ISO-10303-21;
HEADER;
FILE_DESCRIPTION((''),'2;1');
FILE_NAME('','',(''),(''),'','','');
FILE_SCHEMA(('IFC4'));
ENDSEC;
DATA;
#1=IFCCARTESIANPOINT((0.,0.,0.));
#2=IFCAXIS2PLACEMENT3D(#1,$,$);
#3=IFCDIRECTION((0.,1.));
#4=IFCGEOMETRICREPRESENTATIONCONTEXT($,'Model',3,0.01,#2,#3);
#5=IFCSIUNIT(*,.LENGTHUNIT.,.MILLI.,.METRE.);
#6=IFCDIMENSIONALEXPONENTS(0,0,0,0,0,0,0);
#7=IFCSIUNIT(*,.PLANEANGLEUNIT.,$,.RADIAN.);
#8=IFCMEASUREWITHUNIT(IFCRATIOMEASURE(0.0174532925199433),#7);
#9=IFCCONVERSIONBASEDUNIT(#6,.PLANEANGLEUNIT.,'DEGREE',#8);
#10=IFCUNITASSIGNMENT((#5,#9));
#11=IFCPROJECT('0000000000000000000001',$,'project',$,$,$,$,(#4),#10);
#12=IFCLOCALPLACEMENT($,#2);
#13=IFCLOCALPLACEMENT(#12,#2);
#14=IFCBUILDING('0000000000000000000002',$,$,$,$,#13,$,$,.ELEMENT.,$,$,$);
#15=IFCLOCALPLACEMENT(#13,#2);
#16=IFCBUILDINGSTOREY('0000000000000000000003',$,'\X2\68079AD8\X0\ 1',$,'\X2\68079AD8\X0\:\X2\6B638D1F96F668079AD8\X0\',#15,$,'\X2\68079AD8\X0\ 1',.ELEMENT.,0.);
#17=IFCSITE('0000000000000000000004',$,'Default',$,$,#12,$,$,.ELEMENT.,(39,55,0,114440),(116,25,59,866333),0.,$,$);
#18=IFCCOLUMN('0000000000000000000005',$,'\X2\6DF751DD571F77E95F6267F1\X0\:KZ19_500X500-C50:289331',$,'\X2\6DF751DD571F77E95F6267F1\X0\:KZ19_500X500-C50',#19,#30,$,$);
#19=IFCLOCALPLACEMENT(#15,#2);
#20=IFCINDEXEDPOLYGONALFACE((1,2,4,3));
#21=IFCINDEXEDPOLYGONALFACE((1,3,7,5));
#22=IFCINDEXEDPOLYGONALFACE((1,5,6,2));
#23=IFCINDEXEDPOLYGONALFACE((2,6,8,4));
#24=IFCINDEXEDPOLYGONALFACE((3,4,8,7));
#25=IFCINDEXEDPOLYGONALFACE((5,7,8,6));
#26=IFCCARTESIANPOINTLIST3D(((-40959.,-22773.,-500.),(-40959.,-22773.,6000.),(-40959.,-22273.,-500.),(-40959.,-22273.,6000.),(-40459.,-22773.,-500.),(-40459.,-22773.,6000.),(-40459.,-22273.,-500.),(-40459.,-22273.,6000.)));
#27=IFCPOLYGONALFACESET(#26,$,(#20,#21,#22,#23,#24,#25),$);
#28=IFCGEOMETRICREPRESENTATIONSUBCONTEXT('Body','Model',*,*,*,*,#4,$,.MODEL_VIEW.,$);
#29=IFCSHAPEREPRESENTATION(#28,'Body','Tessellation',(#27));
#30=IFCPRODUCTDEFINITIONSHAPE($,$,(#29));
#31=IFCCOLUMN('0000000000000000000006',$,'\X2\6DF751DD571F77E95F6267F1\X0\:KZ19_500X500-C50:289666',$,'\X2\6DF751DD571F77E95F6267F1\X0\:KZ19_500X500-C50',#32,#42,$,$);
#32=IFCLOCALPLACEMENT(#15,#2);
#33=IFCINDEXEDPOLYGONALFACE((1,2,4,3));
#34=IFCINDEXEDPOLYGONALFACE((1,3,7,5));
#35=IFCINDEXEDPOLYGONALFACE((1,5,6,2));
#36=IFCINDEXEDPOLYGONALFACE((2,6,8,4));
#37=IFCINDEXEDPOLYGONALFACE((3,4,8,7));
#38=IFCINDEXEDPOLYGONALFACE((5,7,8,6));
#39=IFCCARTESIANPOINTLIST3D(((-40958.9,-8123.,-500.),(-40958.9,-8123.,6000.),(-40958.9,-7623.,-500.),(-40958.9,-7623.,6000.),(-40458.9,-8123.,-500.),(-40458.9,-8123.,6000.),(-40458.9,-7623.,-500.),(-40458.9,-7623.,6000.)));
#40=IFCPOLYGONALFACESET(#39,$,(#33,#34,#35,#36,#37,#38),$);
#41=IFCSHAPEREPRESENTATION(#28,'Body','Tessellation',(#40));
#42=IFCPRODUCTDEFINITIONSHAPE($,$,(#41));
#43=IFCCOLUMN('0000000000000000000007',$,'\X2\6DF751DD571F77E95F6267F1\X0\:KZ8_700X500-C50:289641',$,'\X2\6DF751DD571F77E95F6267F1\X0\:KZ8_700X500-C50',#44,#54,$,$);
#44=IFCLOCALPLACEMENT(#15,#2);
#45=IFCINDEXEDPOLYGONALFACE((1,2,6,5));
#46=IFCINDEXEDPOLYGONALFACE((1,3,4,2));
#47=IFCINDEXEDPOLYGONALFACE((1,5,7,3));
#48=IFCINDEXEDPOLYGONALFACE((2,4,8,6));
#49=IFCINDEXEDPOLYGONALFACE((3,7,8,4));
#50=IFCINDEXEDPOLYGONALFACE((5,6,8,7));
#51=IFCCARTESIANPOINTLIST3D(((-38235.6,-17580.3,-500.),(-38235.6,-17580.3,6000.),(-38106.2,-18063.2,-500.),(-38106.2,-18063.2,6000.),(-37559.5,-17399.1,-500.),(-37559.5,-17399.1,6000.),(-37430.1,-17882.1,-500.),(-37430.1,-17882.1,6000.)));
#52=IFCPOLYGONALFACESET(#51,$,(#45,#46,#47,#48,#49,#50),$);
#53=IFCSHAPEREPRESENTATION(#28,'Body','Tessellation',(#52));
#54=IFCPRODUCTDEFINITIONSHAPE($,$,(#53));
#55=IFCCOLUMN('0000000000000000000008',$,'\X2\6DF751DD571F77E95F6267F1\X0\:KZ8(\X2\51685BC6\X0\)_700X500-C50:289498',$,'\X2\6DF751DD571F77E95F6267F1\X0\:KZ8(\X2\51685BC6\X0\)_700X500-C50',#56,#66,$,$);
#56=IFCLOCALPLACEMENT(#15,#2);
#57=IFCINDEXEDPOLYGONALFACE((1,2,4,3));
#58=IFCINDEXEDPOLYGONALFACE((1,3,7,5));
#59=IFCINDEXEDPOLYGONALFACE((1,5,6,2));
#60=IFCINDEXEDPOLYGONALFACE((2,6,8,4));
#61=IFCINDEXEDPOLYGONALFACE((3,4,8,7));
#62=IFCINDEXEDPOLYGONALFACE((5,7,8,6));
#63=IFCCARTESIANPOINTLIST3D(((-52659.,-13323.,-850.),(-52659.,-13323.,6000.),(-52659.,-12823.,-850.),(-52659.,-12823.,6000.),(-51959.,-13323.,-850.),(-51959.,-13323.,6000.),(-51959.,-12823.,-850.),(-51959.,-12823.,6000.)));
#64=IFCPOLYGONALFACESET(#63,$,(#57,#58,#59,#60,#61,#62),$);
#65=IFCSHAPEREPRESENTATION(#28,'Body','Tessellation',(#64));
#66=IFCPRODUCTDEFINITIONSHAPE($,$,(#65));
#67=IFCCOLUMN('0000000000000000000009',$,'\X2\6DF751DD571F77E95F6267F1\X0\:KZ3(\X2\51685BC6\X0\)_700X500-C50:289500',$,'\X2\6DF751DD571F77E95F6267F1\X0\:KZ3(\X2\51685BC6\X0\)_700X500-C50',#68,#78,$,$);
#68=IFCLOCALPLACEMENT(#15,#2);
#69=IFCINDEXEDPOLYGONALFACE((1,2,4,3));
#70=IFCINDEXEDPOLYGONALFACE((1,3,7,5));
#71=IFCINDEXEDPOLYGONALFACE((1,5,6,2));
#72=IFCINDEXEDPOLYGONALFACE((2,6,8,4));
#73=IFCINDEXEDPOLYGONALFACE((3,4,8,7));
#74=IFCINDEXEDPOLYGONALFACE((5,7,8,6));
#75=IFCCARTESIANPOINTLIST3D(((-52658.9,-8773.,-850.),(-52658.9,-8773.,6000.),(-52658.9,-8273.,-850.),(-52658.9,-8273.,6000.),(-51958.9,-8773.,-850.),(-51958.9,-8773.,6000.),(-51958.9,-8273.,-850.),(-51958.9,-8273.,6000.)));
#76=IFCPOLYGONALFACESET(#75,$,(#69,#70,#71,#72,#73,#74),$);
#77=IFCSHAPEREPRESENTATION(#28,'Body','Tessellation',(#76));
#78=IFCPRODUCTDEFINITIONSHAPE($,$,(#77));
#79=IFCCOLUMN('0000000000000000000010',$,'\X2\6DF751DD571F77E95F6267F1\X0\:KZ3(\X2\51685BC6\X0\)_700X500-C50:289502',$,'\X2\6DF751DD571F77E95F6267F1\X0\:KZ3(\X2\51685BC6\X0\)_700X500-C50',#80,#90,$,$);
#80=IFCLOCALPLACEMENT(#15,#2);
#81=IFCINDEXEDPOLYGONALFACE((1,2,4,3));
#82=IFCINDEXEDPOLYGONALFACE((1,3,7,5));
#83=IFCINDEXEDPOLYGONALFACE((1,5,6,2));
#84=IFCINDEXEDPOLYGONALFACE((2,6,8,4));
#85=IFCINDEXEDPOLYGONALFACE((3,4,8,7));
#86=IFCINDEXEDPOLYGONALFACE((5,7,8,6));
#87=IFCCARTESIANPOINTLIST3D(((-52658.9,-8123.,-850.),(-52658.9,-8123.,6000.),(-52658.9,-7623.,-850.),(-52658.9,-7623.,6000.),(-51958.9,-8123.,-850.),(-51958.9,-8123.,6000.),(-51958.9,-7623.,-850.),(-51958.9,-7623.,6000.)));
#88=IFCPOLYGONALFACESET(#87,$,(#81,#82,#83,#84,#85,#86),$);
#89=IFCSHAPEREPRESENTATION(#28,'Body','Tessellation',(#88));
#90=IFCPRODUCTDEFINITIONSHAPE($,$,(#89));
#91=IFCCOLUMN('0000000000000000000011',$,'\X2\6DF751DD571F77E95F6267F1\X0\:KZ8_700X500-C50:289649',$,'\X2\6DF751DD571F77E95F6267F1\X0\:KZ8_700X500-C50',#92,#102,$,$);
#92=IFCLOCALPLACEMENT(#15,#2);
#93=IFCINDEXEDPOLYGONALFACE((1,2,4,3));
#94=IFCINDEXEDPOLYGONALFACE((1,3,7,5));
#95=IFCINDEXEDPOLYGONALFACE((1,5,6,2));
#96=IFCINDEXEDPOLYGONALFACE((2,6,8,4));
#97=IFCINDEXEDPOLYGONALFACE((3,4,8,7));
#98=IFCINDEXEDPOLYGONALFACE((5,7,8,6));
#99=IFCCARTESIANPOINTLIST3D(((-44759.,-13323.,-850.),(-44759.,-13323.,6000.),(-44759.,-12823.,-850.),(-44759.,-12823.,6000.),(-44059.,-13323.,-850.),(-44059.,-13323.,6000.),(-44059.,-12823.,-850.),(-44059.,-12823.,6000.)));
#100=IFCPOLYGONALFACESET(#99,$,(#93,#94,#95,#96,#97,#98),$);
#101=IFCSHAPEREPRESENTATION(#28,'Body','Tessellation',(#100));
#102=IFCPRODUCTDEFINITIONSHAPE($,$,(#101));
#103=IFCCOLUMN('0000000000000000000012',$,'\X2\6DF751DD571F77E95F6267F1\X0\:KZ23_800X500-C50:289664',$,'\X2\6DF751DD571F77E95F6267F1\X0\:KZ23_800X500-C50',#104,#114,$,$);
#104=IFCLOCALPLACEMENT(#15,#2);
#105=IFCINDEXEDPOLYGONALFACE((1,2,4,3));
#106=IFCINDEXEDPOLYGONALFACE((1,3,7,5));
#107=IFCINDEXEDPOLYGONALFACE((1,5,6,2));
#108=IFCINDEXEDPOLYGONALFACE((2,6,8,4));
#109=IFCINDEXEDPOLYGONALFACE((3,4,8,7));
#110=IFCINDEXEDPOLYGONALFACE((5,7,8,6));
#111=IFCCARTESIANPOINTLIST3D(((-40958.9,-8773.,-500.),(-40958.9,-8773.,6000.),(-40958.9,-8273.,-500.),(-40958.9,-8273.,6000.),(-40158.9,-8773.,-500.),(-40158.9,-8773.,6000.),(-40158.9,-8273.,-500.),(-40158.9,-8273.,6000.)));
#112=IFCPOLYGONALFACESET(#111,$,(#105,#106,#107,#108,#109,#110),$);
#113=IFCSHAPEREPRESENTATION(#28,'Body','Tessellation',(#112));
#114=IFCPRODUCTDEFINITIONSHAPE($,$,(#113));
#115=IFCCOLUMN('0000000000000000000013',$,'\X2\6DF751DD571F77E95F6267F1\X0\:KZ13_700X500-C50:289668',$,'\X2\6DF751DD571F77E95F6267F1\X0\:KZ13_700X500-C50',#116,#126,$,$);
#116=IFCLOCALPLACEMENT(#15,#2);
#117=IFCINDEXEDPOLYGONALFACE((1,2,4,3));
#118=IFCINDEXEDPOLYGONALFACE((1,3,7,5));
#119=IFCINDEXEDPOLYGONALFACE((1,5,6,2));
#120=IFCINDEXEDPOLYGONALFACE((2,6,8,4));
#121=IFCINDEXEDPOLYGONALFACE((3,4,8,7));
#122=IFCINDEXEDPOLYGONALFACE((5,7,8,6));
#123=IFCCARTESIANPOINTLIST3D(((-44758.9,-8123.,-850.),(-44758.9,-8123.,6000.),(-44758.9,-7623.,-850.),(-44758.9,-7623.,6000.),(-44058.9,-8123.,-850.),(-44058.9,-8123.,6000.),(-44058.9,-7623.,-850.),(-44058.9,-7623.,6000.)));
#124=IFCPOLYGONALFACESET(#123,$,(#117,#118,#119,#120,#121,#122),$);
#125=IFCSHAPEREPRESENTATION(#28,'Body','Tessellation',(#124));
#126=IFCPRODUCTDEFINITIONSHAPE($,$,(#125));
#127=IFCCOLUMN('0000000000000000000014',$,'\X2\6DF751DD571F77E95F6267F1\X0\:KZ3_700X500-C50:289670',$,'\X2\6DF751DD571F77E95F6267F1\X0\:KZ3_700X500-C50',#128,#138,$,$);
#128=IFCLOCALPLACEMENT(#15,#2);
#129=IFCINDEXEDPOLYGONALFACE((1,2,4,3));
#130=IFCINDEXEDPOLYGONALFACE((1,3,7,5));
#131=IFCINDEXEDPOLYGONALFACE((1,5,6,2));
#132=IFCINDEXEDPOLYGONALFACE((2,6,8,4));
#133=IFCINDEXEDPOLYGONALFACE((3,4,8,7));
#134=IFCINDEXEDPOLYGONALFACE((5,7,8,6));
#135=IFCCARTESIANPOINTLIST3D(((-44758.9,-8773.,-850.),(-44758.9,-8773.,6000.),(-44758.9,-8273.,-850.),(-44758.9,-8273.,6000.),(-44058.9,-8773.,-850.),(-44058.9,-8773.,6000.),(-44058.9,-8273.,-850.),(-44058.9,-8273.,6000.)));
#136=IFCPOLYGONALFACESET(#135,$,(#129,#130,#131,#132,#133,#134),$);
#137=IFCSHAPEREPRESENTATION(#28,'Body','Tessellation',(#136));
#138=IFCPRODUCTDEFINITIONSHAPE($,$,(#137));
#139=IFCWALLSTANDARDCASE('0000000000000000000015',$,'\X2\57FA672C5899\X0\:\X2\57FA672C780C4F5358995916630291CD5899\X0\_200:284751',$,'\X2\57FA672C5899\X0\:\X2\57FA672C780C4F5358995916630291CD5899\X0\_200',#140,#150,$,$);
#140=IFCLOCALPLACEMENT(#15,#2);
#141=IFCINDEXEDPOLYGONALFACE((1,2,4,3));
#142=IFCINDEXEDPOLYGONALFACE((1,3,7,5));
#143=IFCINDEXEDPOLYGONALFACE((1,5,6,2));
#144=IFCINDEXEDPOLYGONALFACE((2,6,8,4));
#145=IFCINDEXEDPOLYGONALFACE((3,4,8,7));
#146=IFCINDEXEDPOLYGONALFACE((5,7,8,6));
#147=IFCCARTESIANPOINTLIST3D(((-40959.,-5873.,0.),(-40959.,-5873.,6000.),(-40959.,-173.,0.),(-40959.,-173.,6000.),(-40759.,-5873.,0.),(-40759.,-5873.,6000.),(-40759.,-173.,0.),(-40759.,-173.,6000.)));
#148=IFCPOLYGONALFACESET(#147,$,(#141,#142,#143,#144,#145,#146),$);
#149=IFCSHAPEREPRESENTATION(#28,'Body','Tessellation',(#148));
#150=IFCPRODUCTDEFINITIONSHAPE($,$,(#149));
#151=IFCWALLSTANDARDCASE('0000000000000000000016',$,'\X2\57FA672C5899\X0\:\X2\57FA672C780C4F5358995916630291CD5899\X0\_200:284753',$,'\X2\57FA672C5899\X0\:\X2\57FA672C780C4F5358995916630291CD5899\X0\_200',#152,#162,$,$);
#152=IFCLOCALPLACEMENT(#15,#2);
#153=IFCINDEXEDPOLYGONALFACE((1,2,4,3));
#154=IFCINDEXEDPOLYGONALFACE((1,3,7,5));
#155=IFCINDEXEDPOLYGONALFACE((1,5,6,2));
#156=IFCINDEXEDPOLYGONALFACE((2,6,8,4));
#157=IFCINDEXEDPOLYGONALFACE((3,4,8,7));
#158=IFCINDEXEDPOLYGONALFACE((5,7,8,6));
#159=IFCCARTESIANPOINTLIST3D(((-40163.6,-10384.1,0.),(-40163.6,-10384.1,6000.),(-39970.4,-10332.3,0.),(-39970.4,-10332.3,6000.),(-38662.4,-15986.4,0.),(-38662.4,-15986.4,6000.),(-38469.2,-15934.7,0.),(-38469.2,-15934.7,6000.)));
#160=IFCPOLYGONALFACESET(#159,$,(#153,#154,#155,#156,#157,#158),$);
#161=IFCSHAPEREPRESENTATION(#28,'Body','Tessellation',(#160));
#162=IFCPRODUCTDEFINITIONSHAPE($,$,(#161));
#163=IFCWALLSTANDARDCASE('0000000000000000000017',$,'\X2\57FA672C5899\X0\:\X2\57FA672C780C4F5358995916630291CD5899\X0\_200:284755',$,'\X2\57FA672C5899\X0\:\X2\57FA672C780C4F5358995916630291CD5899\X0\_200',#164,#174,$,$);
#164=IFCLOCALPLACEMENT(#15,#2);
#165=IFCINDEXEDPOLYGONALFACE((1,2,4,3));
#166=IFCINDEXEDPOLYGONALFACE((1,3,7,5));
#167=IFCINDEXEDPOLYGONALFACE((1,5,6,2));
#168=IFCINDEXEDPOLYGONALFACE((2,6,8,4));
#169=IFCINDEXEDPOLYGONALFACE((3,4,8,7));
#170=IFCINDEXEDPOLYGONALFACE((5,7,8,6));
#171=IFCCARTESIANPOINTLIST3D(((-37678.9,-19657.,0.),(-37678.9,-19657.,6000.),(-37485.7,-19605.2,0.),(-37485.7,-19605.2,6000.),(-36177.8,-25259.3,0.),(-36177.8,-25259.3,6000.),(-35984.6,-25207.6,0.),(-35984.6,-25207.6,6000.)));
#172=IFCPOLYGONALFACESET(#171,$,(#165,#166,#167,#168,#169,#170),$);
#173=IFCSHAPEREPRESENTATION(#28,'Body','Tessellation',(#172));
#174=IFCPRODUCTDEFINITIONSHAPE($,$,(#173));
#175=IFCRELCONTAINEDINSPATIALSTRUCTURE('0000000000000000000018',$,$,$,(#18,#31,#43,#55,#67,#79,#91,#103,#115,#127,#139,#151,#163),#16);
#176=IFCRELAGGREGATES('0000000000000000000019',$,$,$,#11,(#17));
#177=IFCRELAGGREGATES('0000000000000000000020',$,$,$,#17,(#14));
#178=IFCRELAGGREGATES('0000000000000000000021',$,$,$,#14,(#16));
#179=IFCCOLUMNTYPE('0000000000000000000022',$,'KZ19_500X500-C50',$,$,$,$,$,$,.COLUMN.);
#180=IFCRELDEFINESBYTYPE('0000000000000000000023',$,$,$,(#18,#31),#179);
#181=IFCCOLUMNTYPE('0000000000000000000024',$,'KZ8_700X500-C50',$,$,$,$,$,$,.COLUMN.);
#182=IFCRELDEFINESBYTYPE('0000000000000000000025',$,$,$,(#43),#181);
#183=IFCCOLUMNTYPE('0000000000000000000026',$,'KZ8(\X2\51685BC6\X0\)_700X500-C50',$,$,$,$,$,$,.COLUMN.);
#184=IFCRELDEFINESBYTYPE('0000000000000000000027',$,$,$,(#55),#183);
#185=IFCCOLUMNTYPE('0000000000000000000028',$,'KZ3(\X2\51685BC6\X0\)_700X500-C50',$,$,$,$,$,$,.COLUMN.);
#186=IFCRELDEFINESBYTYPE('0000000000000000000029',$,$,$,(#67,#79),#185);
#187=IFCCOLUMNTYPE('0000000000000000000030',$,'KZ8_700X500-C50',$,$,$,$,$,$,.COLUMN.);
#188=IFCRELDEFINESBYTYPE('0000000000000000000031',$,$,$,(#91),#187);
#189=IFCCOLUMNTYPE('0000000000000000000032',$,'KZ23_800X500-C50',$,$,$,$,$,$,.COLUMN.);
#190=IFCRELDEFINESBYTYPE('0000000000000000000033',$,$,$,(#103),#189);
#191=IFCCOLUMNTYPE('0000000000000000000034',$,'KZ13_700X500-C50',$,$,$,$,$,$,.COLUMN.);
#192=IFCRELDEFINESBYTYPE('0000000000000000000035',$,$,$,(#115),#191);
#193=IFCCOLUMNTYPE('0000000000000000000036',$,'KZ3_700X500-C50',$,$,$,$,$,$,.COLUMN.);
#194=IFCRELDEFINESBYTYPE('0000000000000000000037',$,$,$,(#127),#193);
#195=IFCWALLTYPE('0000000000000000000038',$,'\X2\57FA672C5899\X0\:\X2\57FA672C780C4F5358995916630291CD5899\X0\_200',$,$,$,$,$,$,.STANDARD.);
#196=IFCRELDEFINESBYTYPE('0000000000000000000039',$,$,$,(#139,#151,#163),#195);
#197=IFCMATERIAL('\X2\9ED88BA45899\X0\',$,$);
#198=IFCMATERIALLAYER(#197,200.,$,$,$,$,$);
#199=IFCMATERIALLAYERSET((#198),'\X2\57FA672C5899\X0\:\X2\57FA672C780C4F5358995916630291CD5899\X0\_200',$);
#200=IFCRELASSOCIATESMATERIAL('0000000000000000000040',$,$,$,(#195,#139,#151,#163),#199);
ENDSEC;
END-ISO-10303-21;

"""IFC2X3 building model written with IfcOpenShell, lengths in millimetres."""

from ifc_helpers import new_model, entity, si_unit, converted_unit, direction, frame, frame_2d, origin, origin_2d_with_axis, place, context, subcontext, project, spatial, rectangle, extrude, source, transform, mapped, material, layer, layer_set, layer_usage, type_object, type_shapes, element, save


model = new_model("IFC2X3")

# Units and contexts
model_context = context("Model", 3, precision=0.01, world=origin(), true_north=direction((0.0, 1.0)))
body_context = subcontext(model_context, "Body", "Model", "MODEL_VIEW")
ifc_project = project(units=[si_unit("LENGTHUNIT", "METRE", prefix="MILLI"), converted_unit("PLANEANGLEUNIT", "DEGREE", entity("IfcRatioMeasure", 0.0174532925199433), si_unit("PLANEANGLEUNIT", "RADIAN"), dimensions=[0, 0, 0, 0, 0, 0, 0])], contexts=[model_context])

# Site, building, storey
site_placement = place(None, origin())
site = spatial("IfcSite", under=ifc_project, at=site_placement, Name="Default", CompositionType="ELEMENT", RefLatitude=(39, 55, 0, 114440), RefLongitude=(116, 25, 59, 866333), RefElevation=0.0)
building_placement = place(site_placement, origin())
building = spatial("IfcBuilding", under=site, at=building_placement, CompositionType="ELEMENT")
storey_placement = place(building_placement, origin())
storey = spatial("IfcBuildingStorey", under=building, at=storey_placement, Name="标高 1", ObjectType="标高:正负零标高", LongName="标高 1", CompositionType="ELEMENT", Elevation=0.0)

# Columns
column_type_1 = type_object("IfcColumnType", Name="KZ19_500X500-C50", PredefinedType="COLUMN")
shared_shape_1 = source(origin(), body_context, "Body", "SweptSolid", [
    extrude(rectangle(XDim=500.0, YDim=500.0, at=origin_2d_with_axis()), frame((0.0, 0.0, -500.0), z_axis=(0.0, 0.0, 1.0), x_axis=(0.0, -1.0, 0.0)), (0.0, 0.0, 1.0), 6500.0),
])
type_shapes(column_type_1, [shared_shape_1])
for number, where, name in (
    (1, (-40709.0, -22523.0, 0.0), "混凝土矩形柱:KZ19_500X500-C50:289331"),
    (2, (-40708.9, -7873.0, 0.0), "混凝土矩形柱:KZ19_500X500-C50:289666"),
):
    element("IfcColumn", number, at=place(building_placement, frame(where)), inside=storey, type_object=column_type_1, Name=name, ObjectType="混凝土矩形柱:KZ19_500X500-C50", context=body_context, shape_type="MappedRepresentation", body=[
        mapped(shared_shape_1, transform((0.0, 0.0, 0.0), scale=1.0)),
    ])
column_type_2 = type_object("IfcColumnType", Name="KZ8_700X500-C50", PredefinedType="COLUMN")
shared_shape_2 = source(origin(), body_context, "Body", "SweptSolid", [
    extrude(rectangle(XDim=500.0, YDim=700.0, at=origin_2d_with_axis()), frame((0.0, 0.0, -500.0), z_axis=(0.0, 0.0, 1.0), x_axis=(0.0, -1.0, 0.0)), (0.0, 0.0, 1.0), 6500.0),
])
type_shapes(column_type_2, [shared_shape_2])
column_1_placement = place(building_placement, frame((-37832.9, -17731.2, 0.0), z_axis=(0.0, 0.0, 1.0), x_axis=(0.965926, 0.258819, 0.0)))
element("IfcColumn", 3, at=column_1_placement, inside=storey, type_object=column_type_2, Name="混凝土矩形柱:KZ8_700X500-C50:289641", ObjectType="混凝土矩形柱:KZ8_700X500-C50", context=body_context, shape_type="MappedRepresentation", body=[
    mapped(shared_shape_2, transform((0.0, 0.0, 0.0), scale=1.0)),
])
column_type_3 = type_object("IfcColumnType", Name="KZ8(全密)_700X500-C50", PredefinedType="COLUMN")
shared_shape_3 = source(origin(), body_context, "Body", "SweptSolid", [
    extrude(rectangle(XDim=500.0, YDim=700.0, at=origin_2d_with_axis()), frame((0.0, 0.0, -850.0), z_axis=(0.0, 0.0, 1.0), x_axis=(0.0, -1.0, 0.0)), (0.0, 0.0, 1.0), 6850.0),
])
type_shapes(column_type_3, [shared_shape_3])
column_2_placement = place(building_placement, frame((-52309.0, -13073.0, 0.0)))
element("IfcColumn", 4, at=column_2_placement, inside=storey, type_object=column_type_3, Name="混凝土矩形柱:KZ8(全密)_700X500-C50:289498", ObjectType="混凝土矩形柱:KZ8(全密)_700X500-C50", context=body_context, shape_type="MappedRepresentation", body=[
    mapped(shared_shape_3, transform((0.0, 0.0, 0.0), scale=1.0)),
])
column_type_4 = type_object("IfcColumnType", Name="KZ3(全密)_700X500-C50", PredefinedType="COLUMN")
shared_shape_4 = source(origin(), body_context, "Body", "SweptSolid", [
    extrude(rectangle(XDim=500.0, YDim=700.0, at=origin_2d_with_axis()), frame((0.0, 0.0, -850.0), z_axis=(0.0, 0.0, 1.0), x_axis=(0.0, -1.0, 0.0)), (0.0, 0.0, 1.0), 6850.0),
])
type_shapes(column_type_4, [shared_shape_4])
for number, where, name in (
    (5, (-52308.9, -8523.0, 0.0), "混凝土矩形柱:KZ3(全密)_700X500-C50:289500"),
    (6, (-52308.9, -7873.0, 0.0), "混凝土矩形柱:KZ3(全密)_700X500-C50:289502"),
):
    element("IfcColumn", number, at=place(building_placement, frame(where)), inside=storey, type_object=column_type_4, Name=name, ObjectType="混凝土矩形柱:KZ3(全密)_700X500-C50", context=body_context, shape_type="MappedRepresentation", body=[
        mapped(shared_shape_4, transform((0.0, 0.0, 0.0), scale=1.0)),
    ])
column_type_5 = type_object("IfcColumnType", Name="KZ8_700X500-C50", PredefinedType="COLUMN")
shared_shape_5 = source(origin(), body_context, "Body", "SweptSolid", [
    extrude(rectangle(XDim=500.0, YDim=700.0, at=origin_2d_with_axis()), frame((0.0, 0.0, -850.0), z_axis=(0.0, 0.0, 1.0), x_axis=(0.0, -1.0, 0.0)), (0.0, 0.0, 1.0), 6850.0),
])
type_shapes(column_type_5, [shared_shape_5])
column_3_placement = place(building_placement, frame((-44409.0, -13073.0, 0.0)))
element("IfcColumn", 7, at=column_3_placement, inside=storey, type_object=column_type_5, Name="混凝土矩形柱:KZ8_700X500-C50:289649", ObjectType="混凝土矩形柱:KZ8_700X500-C50", context=body_context, shape_type="MappedRepresentation", body=[
    mapped(shared_shape_5, transform((0.0, 0.0, 0.0), scale=1.0)),
])
column_type_6 = type_object("IfcColumnType", Name="KZ23_800X500-C50", PredefinedType="COLUMN")
shared_shape_6 = source(origin(), body_context, "Body", "SweptSolid", [
    extrude(rectangle(XDim=500.0, YDim=800.0, at=origin_2d_with_axis()), frame((0.0, 0.0, -500.0), z_axis=(0.0, 0.0, 1.0), x_axis=(0.0, -1.0, 0.0)), (0.0, 0.0, 1.0), 6500.0),
])
type_shapes(column_type_6, [shared_shape_6])
column_4_placement = place(building_placement, frame((-40558.9, -8523.0, 0.0)))
element("IfcColumn", 8, at=column_4_placement, inside=storey, type_object=column_type_6, Name="混凝土矩形柱:KZ23_800X500-C50:289664", ObjectType="混凝土矩形柱:KZ23_800X500-C50", context=body_context, shape_type="MappedRepresentation", body=[
    mapped(shared_shape_6, transform((0.0, 0.0, 0.0), scale=1.0)),
])
column_type_7 = type_object("IfcColumnType", Name="KZ13_700X500-C50", PredefinedType="COLUMN")
shared_shape_7 = source(origin(), body_context, "Body", "SweptSolid", [
    extrude(rectangle(XDim=500.0, YDim=700.0, at=origin_2d_with_axis()), frame((0.0, 0.0, -850.0), z_axis=(0.0, 0.0, 1.0), x_axis=(0.0, -1.0, 0.0)), (0.0, 0.0, 1.0), 6850.0),
])
type_shapes(column_type_7, [shared_shape_7])
column_5_placement = place(building_placement, frame((-44408.9, -7873.0, 0.0)))
element("IfcColumn", 9, at=column_5_placement, inside=storey, type_object=column_type_7, Name="混凝土矩形柱:KZ13_700X500-C50:289668", ObjectType="混凝土矩形柱:KZ13_700X500-C50", context=body_context, shape_type="MappedRepresentation", body=[
    mapped(shared_shape_7, transform((0.0, 0.0, 0.0), scale=1.0)),
])
column_type_8 = type_object("IfcColumnType", Name="KZ3_700X500-C50", PredefinedType="COLUMN")
shared_shape_8 = source(origin(), body_context, "Body", "SweptSolid", [
    extrude(rectangle(XDim=500.0, YDim=700.0, at=origin_2d_with_axis()), frame((0.0, 0.0, -850.0), z_axis=(0.0, 0.0, 1.0), x_axis=(0.0, -1.0, 0.0)), (0.0, 0.0, 1.0), 6850.0),
])
type_shapes(column_type_8, [shared_shape_8])
column_6_placement = place(building_placement, frame((-44408.9, -8523.0, 0.0)))
element("IfcColumn", 10, at=column_6_placement, inside=storey, type_object=column_type_8, Name="混凝土矩形柱:KZ3_700X500-C50:289670", ObjectType="混凝土矩形柱:KZ3_700X500-C50", context=body_context, shape_type="MappedRepresentation", body=[
    mapped(shared_shape_8, transform((0.0, 0.0, 0.0), scale=1.0)),
])

# Walls
ifc_material = material(Name="默认墙")
ifc_layer_1 = layer(ifc_material, 200.0)
ifc_layer_set_1 = layer_set([ifc_layer_1], Name="基本墙:基本砌体墙外挂重墙_200")
ifc_layer_usage_1 = layer_usage(ifc_layer_set_1, "AXIS2", "NEGATIVE", 100.0)
wall_type_1 = type_object("IfcWallType", Name="基本墙:基本砌体墙外挂重墙_200", PredefinedType="STANDARD", material=ifc_layer_set_1)
wall_1_placement = place(building_placement, frame((-40859.0, -5873.0, 0.0), z_axis=(0.0, 0.0, 1.0), x_axis=(0.0, 1.0, 0.0)))
element("IfcWallStandardCase", 11, at=wall_1_placement, inside=storey, type_object=wall_type_1, material=ifc_layer_usage_1, Name="基本墙:基本砌体墙外挂重墙_200:284751", ObjectType="基本墙:基本砌体墙外挂重墙_200", context=body_context, shape_type="SweptSolid", body=[
    extrude(rectangle(XDim=5700.0, YDim=200.0, at=frame_2d((2850.0, 0.0), x_axis=(-1.0, 0.0))), origin(), (0.0, 0.0, 1.0), 6000.0),
])
ifc_layer_usage_2 = layer_usage(ifc_layer_set_1, "AXIS2", "NEGATIVE", 100.0)
wall_2_placement = place(building_placement, frame((-38565.8, -15960.6, 0.0), z_axis=(0.0, 0.0, 1.0), x_axis=(-0.258819, 0.965926, 0.0)))
element("IfcWallStandardCase", 12, at=wall_2_placement, inside=storey, type_object=wall_type_1, material=ifc_layer_usage_2, Name="基本墙:基本砌体墙外挂重墙_200:284753", ObjectType="基本墙:基本砌体墙外挂重墙_200", context=body_context, shape_type="SweptSolid", body=[
    extrude(rectangle(XDim=5800.0, YDim=200.0, at=frame_2d((2900.0, 0.0), x_axis=(-1.0, 0.0))), origin(), (0.0, 0.0, 1.0), 6000.0),
])
ifc_layer_usage_3 = layer_usage(ifc_layer_set_1, "AXIS2", "NEGATIVE", 100.0)
wall_3_placement = place(building_placement, frame((-36081.2, -25233.4, 0.0), z_axis=(0.0, 0.0, 1.0), x_axis=(-0.258819, 0.965926, 0.0)))
element("IfcWallStandardCase", 13, at=wall_3_placement, inside=storey, type_object=wall_type_1, material=ifc_layer_usage_3, Name="基本墙:基本砌体墙外挂重墙_200:284755", ObjectType="基本墙:基本砌体墙外挂重墙_200", context=body_context, shape_type="SweptSolid", body=[
    extrude(rectangle(XDim=5800.0, YDim=200.0, at=frame_2d((2900.0, 0.0), x_axis=(-1.0, 0.0))), origin(), (0.0, 0.0, 1.0), 6000.0),
])

save(model, "model.ifc")
